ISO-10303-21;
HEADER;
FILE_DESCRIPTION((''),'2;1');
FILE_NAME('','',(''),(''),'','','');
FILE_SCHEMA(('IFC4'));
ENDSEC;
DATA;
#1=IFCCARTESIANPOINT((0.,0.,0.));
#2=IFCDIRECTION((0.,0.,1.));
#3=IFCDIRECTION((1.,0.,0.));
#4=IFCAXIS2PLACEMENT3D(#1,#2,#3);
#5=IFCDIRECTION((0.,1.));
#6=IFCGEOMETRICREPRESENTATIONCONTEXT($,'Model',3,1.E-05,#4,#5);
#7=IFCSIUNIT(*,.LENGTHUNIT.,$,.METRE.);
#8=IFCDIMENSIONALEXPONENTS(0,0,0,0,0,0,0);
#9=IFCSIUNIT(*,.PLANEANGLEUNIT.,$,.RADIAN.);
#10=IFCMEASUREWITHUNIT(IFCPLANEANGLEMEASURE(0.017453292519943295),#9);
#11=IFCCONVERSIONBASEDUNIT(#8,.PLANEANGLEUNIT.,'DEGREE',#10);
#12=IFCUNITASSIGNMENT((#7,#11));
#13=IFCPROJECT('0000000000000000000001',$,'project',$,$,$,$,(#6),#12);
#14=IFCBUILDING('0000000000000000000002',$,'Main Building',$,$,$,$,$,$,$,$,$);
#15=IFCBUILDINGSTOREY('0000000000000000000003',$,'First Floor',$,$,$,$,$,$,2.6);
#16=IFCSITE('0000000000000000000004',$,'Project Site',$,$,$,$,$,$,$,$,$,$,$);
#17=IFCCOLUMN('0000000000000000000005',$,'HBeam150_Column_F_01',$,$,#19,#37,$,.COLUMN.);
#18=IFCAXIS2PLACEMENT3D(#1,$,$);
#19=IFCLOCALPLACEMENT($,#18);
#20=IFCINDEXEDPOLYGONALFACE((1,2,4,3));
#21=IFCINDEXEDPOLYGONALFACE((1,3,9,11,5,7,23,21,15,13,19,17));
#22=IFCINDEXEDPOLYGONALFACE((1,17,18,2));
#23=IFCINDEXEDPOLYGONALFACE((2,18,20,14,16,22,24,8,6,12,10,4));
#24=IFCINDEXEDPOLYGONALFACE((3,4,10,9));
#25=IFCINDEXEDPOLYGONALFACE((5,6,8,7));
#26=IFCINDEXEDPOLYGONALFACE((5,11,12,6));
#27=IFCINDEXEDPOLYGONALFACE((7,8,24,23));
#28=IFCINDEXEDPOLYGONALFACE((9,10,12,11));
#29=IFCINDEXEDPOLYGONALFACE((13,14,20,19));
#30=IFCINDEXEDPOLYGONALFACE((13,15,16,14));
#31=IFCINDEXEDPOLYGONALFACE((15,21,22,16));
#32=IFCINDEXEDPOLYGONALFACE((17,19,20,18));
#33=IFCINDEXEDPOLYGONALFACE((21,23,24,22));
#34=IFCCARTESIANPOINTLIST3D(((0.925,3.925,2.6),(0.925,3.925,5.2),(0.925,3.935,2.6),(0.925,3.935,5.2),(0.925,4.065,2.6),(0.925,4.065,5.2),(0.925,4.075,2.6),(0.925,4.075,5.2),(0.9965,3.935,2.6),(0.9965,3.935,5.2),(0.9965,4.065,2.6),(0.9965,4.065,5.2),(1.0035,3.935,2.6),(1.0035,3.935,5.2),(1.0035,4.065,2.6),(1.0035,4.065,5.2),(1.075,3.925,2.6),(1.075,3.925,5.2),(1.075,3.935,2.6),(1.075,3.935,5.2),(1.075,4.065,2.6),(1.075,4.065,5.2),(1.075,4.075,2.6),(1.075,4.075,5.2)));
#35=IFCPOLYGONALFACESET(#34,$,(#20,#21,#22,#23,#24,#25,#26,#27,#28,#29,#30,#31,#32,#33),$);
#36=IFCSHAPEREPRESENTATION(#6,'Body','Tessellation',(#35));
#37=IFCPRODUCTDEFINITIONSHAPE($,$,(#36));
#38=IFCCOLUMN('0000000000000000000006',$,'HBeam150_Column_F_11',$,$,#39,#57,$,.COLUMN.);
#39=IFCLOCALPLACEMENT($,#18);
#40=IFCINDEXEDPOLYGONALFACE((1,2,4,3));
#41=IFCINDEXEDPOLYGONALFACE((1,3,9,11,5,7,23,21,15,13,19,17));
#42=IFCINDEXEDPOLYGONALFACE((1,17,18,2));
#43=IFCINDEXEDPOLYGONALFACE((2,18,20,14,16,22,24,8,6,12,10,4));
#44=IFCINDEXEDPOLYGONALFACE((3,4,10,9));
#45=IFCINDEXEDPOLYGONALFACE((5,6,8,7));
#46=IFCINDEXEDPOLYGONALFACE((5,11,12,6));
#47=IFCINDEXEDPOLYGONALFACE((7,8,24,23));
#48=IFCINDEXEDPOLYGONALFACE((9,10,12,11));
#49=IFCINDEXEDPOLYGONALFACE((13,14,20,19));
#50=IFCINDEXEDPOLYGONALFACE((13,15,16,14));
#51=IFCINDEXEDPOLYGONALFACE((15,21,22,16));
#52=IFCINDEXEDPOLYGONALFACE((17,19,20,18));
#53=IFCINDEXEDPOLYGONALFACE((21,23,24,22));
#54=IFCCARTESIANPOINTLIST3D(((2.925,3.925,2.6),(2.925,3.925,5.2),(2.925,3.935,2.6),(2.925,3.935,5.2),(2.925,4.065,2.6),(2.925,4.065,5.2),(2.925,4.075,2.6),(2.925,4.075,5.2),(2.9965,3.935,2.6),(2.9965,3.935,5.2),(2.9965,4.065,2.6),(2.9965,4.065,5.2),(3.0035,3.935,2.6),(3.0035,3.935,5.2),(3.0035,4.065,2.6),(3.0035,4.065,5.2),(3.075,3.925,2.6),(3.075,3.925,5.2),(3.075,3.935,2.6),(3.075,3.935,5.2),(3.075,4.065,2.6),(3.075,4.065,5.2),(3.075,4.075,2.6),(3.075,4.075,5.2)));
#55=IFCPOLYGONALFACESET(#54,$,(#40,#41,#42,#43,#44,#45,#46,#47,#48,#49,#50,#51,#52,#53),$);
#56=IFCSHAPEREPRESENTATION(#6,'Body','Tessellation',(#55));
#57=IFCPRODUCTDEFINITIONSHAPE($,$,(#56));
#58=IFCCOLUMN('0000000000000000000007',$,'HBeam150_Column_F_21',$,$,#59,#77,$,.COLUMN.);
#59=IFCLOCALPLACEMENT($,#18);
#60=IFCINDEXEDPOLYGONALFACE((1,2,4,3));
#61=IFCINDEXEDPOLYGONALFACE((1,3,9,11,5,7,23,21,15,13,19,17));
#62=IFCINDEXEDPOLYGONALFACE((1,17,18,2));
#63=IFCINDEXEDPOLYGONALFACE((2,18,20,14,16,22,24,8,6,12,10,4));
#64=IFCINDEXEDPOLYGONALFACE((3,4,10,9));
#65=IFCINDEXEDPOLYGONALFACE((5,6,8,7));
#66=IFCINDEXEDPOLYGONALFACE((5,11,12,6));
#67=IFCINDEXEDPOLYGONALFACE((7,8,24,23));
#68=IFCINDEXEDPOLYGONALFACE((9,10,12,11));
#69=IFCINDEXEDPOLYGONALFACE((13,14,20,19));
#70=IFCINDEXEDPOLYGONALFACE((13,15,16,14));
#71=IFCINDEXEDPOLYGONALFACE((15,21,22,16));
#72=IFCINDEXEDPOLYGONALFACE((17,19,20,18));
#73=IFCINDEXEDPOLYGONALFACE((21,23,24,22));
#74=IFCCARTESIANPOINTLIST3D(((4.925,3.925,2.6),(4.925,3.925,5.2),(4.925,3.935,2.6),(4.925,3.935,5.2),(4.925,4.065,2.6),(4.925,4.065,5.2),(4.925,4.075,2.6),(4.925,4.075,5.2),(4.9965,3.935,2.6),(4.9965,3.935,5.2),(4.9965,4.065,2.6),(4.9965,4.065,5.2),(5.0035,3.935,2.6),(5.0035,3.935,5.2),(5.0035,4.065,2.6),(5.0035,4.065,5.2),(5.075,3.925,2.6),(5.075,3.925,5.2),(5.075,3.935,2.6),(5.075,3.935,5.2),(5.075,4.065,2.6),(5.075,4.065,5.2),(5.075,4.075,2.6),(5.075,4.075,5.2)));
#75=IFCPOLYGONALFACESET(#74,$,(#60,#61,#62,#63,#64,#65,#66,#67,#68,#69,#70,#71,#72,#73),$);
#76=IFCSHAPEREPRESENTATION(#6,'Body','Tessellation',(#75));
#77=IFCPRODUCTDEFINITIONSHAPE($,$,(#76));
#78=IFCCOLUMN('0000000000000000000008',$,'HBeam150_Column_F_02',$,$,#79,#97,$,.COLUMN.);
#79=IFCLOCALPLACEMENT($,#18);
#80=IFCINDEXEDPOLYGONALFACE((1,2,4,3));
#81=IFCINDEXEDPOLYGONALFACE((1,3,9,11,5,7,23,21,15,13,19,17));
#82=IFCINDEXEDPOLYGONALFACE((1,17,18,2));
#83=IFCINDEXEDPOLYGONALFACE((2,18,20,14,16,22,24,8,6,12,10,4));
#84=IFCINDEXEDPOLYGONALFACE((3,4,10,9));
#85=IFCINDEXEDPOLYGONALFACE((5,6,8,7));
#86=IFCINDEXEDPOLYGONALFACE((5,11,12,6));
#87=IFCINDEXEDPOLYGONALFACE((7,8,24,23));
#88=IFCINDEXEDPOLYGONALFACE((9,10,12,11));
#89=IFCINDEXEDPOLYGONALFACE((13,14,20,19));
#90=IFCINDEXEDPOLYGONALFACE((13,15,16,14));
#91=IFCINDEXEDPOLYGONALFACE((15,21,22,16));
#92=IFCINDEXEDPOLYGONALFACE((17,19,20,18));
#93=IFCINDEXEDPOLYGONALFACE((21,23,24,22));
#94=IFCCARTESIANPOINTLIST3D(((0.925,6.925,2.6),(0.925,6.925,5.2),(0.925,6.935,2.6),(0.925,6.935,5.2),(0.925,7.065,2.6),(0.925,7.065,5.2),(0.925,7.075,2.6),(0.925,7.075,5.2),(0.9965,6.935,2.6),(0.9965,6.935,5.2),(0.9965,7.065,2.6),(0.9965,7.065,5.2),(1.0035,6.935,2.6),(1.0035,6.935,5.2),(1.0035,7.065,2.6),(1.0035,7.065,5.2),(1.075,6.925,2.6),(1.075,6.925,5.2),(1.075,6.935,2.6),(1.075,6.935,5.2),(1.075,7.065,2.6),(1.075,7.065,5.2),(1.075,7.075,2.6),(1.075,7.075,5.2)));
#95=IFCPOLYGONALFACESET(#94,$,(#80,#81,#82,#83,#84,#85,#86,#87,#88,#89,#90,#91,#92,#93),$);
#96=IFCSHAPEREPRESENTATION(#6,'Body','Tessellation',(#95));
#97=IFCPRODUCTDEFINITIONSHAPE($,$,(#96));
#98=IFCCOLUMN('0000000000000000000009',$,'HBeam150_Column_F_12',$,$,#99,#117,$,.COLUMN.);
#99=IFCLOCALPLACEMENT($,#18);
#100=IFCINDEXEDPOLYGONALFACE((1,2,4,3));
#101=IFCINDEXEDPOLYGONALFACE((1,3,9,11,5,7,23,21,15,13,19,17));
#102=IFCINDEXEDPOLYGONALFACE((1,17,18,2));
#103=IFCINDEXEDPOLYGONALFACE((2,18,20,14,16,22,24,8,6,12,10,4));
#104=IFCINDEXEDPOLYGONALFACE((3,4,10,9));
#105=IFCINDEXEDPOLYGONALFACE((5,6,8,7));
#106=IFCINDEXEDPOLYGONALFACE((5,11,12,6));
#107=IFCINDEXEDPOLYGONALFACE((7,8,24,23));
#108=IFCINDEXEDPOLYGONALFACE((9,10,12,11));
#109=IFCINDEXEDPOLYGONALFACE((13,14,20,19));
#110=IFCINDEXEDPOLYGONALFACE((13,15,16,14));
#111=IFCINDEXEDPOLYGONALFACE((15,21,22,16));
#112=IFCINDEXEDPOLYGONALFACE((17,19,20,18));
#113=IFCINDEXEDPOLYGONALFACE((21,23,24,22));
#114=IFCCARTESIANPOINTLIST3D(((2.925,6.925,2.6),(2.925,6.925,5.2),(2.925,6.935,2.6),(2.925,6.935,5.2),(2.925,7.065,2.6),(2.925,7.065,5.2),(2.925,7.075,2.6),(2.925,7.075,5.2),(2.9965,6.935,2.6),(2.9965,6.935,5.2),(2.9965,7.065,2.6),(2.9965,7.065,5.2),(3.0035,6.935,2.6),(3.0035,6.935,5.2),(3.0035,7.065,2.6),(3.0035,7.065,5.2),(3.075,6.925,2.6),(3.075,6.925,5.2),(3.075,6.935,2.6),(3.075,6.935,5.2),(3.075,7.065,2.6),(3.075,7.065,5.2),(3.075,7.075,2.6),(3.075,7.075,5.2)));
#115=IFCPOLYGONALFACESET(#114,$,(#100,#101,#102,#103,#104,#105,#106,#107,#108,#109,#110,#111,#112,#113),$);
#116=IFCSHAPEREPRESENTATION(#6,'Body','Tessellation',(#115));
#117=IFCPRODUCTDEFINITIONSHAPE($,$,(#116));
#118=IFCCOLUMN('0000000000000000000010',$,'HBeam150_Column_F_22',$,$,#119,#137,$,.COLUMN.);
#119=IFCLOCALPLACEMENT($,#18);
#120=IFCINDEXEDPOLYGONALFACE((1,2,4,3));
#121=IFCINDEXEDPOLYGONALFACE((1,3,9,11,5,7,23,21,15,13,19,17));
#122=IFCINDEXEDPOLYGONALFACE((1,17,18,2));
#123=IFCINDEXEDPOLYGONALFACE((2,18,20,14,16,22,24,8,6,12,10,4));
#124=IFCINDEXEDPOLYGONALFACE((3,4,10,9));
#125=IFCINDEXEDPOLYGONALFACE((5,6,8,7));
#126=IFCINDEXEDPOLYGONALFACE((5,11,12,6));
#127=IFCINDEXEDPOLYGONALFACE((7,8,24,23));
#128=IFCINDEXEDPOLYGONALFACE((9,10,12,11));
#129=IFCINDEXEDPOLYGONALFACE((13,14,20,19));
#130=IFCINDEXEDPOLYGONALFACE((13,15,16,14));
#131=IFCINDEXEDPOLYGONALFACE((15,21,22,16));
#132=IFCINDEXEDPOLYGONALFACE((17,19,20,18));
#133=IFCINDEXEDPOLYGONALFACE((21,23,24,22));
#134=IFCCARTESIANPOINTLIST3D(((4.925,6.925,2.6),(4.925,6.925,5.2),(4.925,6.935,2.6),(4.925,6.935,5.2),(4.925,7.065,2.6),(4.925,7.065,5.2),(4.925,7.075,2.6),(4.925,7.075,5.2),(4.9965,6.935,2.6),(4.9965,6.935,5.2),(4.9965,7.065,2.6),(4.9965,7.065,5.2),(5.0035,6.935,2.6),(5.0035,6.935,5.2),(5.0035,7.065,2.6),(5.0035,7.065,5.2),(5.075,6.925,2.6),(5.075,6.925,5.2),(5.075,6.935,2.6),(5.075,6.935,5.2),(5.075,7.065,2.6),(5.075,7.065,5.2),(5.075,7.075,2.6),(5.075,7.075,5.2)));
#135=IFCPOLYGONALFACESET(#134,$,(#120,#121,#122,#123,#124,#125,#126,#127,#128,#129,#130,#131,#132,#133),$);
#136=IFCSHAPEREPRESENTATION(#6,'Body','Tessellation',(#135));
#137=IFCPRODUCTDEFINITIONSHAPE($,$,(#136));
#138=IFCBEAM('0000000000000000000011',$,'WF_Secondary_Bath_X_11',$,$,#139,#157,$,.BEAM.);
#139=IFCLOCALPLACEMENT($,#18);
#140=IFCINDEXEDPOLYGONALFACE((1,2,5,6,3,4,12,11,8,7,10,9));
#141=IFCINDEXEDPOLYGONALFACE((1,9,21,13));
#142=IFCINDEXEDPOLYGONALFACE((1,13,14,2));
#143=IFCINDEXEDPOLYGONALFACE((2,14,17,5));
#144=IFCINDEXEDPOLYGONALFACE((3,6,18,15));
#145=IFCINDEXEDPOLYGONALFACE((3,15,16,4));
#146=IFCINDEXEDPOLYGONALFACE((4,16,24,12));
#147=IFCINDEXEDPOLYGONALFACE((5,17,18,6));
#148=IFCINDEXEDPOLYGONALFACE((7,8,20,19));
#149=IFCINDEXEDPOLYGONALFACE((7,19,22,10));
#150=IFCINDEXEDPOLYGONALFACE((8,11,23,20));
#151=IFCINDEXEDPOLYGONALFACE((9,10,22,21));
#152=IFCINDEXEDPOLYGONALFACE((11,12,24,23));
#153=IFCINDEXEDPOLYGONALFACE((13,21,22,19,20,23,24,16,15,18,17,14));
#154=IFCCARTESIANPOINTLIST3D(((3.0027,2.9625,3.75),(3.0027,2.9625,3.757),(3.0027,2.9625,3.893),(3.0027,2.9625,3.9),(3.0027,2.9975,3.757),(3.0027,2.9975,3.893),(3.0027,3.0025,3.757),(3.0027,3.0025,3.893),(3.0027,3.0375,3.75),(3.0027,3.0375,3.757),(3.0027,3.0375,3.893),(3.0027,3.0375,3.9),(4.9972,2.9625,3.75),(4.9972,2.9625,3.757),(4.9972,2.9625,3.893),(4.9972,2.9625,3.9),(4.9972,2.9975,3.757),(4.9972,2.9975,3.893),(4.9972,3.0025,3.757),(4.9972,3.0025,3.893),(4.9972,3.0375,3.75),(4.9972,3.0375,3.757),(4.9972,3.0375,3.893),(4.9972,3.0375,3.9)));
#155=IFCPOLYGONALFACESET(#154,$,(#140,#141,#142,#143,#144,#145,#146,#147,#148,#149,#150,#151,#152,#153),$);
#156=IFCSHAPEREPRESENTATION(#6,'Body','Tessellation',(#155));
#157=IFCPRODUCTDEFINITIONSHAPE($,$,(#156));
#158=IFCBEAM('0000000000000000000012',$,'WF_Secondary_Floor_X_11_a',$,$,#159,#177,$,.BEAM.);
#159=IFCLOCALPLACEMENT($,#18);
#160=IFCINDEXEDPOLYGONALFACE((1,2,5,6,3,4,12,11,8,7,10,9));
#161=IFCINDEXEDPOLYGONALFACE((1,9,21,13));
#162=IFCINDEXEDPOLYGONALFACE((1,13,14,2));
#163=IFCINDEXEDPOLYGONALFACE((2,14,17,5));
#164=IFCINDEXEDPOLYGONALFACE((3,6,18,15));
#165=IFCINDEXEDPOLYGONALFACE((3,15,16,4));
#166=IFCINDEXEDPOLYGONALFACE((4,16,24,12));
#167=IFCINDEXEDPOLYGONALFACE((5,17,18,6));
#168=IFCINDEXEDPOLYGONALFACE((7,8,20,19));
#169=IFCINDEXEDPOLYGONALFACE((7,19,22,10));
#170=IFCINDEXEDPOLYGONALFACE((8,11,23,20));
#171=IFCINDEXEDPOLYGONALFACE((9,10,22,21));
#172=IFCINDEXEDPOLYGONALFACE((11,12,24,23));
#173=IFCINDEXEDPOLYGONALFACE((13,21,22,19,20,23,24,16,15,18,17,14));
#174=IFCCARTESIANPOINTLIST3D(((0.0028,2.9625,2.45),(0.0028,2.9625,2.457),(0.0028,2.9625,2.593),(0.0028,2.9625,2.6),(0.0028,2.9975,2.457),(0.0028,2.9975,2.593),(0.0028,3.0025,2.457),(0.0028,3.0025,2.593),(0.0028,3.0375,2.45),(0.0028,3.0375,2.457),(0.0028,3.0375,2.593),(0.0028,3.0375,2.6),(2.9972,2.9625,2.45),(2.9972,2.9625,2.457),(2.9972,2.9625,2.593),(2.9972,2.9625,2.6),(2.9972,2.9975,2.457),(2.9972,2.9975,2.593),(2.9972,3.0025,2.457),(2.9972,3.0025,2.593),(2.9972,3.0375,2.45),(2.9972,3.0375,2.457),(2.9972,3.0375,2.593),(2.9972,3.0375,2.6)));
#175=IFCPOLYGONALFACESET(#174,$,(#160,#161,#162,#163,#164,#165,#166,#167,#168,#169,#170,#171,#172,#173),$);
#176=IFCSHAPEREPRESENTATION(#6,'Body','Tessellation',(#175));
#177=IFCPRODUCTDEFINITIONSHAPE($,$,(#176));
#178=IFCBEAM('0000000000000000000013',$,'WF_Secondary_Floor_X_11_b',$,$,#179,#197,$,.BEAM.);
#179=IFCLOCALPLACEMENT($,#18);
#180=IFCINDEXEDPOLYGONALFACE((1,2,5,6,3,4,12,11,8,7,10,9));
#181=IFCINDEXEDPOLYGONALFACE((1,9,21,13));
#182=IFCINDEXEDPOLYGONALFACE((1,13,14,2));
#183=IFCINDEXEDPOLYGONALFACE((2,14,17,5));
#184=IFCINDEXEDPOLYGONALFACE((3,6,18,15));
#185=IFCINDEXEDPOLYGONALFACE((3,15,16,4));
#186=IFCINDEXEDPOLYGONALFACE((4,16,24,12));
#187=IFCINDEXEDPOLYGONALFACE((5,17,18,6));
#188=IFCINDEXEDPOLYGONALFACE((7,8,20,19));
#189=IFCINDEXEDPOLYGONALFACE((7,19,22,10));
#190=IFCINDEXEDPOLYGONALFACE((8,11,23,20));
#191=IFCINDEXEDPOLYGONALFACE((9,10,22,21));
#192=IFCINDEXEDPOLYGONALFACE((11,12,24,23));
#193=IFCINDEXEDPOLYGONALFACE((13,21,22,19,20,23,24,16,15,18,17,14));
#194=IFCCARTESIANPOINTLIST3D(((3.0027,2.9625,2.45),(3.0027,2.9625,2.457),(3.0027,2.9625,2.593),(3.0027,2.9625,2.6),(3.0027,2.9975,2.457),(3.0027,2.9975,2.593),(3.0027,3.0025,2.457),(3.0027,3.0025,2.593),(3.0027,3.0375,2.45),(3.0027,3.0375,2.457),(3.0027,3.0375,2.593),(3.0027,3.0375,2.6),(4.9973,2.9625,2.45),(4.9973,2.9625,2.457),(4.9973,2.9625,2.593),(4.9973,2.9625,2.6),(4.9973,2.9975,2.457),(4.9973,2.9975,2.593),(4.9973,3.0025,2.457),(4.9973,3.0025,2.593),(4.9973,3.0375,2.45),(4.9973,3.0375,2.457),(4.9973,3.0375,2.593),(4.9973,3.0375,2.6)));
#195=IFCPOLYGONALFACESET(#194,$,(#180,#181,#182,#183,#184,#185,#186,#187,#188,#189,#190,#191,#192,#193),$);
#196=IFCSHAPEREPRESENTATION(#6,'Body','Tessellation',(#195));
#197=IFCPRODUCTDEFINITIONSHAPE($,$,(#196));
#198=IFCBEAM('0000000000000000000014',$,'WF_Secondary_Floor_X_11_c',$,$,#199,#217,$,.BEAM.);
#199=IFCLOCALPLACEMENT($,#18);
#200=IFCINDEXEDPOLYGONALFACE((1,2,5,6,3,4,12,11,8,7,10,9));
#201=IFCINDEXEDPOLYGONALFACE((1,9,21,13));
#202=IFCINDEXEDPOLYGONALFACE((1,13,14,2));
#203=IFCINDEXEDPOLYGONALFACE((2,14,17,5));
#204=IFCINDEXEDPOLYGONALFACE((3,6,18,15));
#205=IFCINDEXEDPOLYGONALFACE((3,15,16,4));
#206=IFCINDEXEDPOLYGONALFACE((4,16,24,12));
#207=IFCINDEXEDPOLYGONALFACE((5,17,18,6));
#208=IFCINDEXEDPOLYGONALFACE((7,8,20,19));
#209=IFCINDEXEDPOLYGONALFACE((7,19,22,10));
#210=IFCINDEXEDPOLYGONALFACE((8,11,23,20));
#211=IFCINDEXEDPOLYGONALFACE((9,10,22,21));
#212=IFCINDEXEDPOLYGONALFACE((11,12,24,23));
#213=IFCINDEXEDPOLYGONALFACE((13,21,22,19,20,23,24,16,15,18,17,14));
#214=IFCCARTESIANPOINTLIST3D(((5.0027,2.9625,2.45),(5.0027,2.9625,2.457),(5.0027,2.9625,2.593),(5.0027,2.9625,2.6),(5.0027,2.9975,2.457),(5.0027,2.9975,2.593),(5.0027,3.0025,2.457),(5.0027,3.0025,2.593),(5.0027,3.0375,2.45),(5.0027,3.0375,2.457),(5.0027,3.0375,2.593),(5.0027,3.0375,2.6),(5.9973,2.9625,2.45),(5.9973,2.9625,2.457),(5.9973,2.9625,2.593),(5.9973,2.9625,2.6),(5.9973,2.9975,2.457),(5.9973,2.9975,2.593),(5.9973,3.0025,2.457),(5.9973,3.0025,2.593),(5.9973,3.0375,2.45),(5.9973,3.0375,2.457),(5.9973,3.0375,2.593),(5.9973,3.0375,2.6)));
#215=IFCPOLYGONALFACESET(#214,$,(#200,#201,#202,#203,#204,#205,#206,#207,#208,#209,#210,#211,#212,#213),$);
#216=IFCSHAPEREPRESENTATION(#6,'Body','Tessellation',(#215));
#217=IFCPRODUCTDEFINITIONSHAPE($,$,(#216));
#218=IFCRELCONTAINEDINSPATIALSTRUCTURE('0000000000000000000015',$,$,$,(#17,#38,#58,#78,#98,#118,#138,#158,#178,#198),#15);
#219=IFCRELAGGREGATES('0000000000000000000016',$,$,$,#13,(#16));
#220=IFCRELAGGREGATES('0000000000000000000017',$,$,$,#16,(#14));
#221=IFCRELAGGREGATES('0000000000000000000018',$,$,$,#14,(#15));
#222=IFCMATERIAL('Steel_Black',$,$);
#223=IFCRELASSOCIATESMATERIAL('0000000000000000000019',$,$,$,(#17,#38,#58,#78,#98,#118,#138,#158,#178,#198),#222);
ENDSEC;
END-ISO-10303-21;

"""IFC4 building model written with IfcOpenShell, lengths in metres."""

from ifc_helpers import new_model, entity, si_unit, converted_unit, direction, frame, frame_2d, origin, origin_with_axes, origin_2d, place, context, project, spatial, i_section, extrude, material, element, save


model = new_model("IFC4")

# Units and contexts
model_context = context("Model", 3, precision=1e-05, world=origin_with_axes(), true_north=direction((0.0, 1.0)))
ifc_project = project(units=[si_unit("LENGTHUNIT", "METRE"), converted_unit("PLANEANGLEUNIT", "DEGREE", entity("IfcPlaneAngleMeasure", 0.017453292519943295), si_unit("PLANEANGLEUNIT", "RADIAN"), dimensions=[0, 0, 0, 0, 0, 0, 0])], contexts=[model_context])

# Site, building, storey
site = spatial("IfcSite", under=ifc_project, Name="Project Site")
building = spatial("IfcBuilding", under=site, Name="Main Building")
storey = spatial("IfcBuildingStorey", under=building, Name="First Floor", Elevation=2.6)

# Columns
ifc_material = material(Name="Steel_Black")
for number, where, z_axis, x_axis, name in (
    (1, (1.0, 4.0, 2.6), (0.0, 0.0, 1.0), (1.0, 0.0, 0.0), "HBeam150_Column_F_01"),
    (2, (3.0, 4.0, 2.6), (0.0, 0.0, 1.0), (1.0, 0.0, 0.0), "HBeam150_Column_F_11"),
    (3, (5.0, 4.0, 2.6), (0.0, 0.0, 1.0), (1.0, 0.0, 0.0), "HBeam150_Column_F_21"),
    (4, (1.0, 7.0, 2.6), (0.0, 0.0, 1.0), (1.0, 0.0, 0.0), "HBeam150_Column_F_02"),
    (5, (3.0, 7.0, 2.6), (0.0, 0.0, 1.0), (1.0, 0.0, 0.0), "HBeam150_Column_F_12"),
    (6, (5.0, 7.0, 2.6), (0.0, 0.0, 1.0), (1.0, 0.0, 0.0), "HBeam150_Column_F_22"),
):
    element("IfcColumn", number, at=place(None, frame(where, z_axis=z_axis, x_axis=x_axis)), inside=storey, material=ifc_material, Name=name, PredefinedType="COLUMN", context=model_context, shape_type="SweptSolid", body=[
        extrude(i_section(OverallWidth=0.15, OverallDepth=0.15, WebThickness=0.007, FlangeThickness=0.01, at=origin_2d()), origin(), (0.0, 0.0, 1.0), 2.6),
    ])

# Beams
beam_1_placement = place(None, frame((3.0027, 3.0, 3.75), z_axis=(0.0, 0.0, 1.0), x_axis=(1.0, 0.0, 0.0)))
element("IfcBeam", 7, at=beam_1_placement, inside=storey, material=ifc_material, Name="WF_Secondary_Bath_X_11", PredefinedType="BEAM", context=model_context, shape_type="SweptSolid", body=[
    extrude(i_section(OverallWidth=0.075, OverallDepth=0.15, WebThickness=0.005, FlangeThickness=0.007, at=frame_2d((0.0, 0.075))), frame((0.0, 0.0, 0.0), z_axis=(1.0, 0.0, 0.0), x_axis=(0.0, 1.0, 0.0)), (0.0, 0.0, 1.0), 1.9945),
])
beam_2_placement = place(None, frame((0.0027, 3.0, 2.45), z_axis=(0.0, 0.0, 1.0), x_axis=(1.0, 0.0, 0.0)))
element("IfcBeam", 8, at=beam_2_placement, inside=storey, material=ifc_material, Name="WF_Secondary_Floor_X_11_a", PredefinedType="BEAM", context=model_context, shape_type="SweptSolid", body=[
    extrude(i_section(OverallWidth=0.075, OverallDepth=0.15, WebThickness=0.005, FlangeThickness=0.007, at=frame_2d((0.0, 0.075))), frame((0.0, 0.0, 0.0), z_axis=(1.0, 0.0, 0.0), x_axis=(0.0, 1.0, 0.0)), (0.0, 0.0, 1.0), 2.9945),
])
beam_3_placement = place(None, frame((3.0027, 3.0, 2.45), z_axis=(0.0, 0.0, 1.0), x_axis=(1.0, 0.0, 0.0)))
element("IfcBeam", 9, at=beam_3_placement, inside=storey, material=ifc_material, Name="WF_Secondary_Floor_X_11_b", PredefinedType="BEAM", context=model_context, shape_type="SweptSolid", body=[
    extrude(i_section(OverallWidth=0.075, OverallDepth=0.15, WebThickness=0.005, FlangeThickness=0.007, at=frame_2d((0.0, 0.075))), frame((0.0, 0.0, 0.0), z_axis=(1.0, 0.0, 0.0), x_axis=(0.0, 1.0, 0.0)), (0.0, 0.0, 1.0), 1.9946),
])
beam_4_placement = place(None, frame((5.0027, 3.0, 2.45), z_axis=(0.0, 0.0, 1.0), x_axis=(1.0, 0.0, 0.0)))
element("IfcBeam", 10, at=beam_4_placement, inside=storey, material=ifc_material, Name="WF_Secondary_Floor_X_11_c", PredefinedType="BEAM", context=model_context, shape_type="SweptSolid", body=[
    extrude(i_section(OverallWidth=0.075, OverallDepth=0.15, WebThickness=0.005, FlangeThickness=0.007, at=frame_2d((0.0, 0.075))), frame((0.0, 0.0, 0.0), z_axis=(1.0, 0.0, 0.0), x_axis=(0.0, 1.0, 0.0)), (0.0, 0.0, 1.0), 0.9946),
])

save(model, "model.ifc")
